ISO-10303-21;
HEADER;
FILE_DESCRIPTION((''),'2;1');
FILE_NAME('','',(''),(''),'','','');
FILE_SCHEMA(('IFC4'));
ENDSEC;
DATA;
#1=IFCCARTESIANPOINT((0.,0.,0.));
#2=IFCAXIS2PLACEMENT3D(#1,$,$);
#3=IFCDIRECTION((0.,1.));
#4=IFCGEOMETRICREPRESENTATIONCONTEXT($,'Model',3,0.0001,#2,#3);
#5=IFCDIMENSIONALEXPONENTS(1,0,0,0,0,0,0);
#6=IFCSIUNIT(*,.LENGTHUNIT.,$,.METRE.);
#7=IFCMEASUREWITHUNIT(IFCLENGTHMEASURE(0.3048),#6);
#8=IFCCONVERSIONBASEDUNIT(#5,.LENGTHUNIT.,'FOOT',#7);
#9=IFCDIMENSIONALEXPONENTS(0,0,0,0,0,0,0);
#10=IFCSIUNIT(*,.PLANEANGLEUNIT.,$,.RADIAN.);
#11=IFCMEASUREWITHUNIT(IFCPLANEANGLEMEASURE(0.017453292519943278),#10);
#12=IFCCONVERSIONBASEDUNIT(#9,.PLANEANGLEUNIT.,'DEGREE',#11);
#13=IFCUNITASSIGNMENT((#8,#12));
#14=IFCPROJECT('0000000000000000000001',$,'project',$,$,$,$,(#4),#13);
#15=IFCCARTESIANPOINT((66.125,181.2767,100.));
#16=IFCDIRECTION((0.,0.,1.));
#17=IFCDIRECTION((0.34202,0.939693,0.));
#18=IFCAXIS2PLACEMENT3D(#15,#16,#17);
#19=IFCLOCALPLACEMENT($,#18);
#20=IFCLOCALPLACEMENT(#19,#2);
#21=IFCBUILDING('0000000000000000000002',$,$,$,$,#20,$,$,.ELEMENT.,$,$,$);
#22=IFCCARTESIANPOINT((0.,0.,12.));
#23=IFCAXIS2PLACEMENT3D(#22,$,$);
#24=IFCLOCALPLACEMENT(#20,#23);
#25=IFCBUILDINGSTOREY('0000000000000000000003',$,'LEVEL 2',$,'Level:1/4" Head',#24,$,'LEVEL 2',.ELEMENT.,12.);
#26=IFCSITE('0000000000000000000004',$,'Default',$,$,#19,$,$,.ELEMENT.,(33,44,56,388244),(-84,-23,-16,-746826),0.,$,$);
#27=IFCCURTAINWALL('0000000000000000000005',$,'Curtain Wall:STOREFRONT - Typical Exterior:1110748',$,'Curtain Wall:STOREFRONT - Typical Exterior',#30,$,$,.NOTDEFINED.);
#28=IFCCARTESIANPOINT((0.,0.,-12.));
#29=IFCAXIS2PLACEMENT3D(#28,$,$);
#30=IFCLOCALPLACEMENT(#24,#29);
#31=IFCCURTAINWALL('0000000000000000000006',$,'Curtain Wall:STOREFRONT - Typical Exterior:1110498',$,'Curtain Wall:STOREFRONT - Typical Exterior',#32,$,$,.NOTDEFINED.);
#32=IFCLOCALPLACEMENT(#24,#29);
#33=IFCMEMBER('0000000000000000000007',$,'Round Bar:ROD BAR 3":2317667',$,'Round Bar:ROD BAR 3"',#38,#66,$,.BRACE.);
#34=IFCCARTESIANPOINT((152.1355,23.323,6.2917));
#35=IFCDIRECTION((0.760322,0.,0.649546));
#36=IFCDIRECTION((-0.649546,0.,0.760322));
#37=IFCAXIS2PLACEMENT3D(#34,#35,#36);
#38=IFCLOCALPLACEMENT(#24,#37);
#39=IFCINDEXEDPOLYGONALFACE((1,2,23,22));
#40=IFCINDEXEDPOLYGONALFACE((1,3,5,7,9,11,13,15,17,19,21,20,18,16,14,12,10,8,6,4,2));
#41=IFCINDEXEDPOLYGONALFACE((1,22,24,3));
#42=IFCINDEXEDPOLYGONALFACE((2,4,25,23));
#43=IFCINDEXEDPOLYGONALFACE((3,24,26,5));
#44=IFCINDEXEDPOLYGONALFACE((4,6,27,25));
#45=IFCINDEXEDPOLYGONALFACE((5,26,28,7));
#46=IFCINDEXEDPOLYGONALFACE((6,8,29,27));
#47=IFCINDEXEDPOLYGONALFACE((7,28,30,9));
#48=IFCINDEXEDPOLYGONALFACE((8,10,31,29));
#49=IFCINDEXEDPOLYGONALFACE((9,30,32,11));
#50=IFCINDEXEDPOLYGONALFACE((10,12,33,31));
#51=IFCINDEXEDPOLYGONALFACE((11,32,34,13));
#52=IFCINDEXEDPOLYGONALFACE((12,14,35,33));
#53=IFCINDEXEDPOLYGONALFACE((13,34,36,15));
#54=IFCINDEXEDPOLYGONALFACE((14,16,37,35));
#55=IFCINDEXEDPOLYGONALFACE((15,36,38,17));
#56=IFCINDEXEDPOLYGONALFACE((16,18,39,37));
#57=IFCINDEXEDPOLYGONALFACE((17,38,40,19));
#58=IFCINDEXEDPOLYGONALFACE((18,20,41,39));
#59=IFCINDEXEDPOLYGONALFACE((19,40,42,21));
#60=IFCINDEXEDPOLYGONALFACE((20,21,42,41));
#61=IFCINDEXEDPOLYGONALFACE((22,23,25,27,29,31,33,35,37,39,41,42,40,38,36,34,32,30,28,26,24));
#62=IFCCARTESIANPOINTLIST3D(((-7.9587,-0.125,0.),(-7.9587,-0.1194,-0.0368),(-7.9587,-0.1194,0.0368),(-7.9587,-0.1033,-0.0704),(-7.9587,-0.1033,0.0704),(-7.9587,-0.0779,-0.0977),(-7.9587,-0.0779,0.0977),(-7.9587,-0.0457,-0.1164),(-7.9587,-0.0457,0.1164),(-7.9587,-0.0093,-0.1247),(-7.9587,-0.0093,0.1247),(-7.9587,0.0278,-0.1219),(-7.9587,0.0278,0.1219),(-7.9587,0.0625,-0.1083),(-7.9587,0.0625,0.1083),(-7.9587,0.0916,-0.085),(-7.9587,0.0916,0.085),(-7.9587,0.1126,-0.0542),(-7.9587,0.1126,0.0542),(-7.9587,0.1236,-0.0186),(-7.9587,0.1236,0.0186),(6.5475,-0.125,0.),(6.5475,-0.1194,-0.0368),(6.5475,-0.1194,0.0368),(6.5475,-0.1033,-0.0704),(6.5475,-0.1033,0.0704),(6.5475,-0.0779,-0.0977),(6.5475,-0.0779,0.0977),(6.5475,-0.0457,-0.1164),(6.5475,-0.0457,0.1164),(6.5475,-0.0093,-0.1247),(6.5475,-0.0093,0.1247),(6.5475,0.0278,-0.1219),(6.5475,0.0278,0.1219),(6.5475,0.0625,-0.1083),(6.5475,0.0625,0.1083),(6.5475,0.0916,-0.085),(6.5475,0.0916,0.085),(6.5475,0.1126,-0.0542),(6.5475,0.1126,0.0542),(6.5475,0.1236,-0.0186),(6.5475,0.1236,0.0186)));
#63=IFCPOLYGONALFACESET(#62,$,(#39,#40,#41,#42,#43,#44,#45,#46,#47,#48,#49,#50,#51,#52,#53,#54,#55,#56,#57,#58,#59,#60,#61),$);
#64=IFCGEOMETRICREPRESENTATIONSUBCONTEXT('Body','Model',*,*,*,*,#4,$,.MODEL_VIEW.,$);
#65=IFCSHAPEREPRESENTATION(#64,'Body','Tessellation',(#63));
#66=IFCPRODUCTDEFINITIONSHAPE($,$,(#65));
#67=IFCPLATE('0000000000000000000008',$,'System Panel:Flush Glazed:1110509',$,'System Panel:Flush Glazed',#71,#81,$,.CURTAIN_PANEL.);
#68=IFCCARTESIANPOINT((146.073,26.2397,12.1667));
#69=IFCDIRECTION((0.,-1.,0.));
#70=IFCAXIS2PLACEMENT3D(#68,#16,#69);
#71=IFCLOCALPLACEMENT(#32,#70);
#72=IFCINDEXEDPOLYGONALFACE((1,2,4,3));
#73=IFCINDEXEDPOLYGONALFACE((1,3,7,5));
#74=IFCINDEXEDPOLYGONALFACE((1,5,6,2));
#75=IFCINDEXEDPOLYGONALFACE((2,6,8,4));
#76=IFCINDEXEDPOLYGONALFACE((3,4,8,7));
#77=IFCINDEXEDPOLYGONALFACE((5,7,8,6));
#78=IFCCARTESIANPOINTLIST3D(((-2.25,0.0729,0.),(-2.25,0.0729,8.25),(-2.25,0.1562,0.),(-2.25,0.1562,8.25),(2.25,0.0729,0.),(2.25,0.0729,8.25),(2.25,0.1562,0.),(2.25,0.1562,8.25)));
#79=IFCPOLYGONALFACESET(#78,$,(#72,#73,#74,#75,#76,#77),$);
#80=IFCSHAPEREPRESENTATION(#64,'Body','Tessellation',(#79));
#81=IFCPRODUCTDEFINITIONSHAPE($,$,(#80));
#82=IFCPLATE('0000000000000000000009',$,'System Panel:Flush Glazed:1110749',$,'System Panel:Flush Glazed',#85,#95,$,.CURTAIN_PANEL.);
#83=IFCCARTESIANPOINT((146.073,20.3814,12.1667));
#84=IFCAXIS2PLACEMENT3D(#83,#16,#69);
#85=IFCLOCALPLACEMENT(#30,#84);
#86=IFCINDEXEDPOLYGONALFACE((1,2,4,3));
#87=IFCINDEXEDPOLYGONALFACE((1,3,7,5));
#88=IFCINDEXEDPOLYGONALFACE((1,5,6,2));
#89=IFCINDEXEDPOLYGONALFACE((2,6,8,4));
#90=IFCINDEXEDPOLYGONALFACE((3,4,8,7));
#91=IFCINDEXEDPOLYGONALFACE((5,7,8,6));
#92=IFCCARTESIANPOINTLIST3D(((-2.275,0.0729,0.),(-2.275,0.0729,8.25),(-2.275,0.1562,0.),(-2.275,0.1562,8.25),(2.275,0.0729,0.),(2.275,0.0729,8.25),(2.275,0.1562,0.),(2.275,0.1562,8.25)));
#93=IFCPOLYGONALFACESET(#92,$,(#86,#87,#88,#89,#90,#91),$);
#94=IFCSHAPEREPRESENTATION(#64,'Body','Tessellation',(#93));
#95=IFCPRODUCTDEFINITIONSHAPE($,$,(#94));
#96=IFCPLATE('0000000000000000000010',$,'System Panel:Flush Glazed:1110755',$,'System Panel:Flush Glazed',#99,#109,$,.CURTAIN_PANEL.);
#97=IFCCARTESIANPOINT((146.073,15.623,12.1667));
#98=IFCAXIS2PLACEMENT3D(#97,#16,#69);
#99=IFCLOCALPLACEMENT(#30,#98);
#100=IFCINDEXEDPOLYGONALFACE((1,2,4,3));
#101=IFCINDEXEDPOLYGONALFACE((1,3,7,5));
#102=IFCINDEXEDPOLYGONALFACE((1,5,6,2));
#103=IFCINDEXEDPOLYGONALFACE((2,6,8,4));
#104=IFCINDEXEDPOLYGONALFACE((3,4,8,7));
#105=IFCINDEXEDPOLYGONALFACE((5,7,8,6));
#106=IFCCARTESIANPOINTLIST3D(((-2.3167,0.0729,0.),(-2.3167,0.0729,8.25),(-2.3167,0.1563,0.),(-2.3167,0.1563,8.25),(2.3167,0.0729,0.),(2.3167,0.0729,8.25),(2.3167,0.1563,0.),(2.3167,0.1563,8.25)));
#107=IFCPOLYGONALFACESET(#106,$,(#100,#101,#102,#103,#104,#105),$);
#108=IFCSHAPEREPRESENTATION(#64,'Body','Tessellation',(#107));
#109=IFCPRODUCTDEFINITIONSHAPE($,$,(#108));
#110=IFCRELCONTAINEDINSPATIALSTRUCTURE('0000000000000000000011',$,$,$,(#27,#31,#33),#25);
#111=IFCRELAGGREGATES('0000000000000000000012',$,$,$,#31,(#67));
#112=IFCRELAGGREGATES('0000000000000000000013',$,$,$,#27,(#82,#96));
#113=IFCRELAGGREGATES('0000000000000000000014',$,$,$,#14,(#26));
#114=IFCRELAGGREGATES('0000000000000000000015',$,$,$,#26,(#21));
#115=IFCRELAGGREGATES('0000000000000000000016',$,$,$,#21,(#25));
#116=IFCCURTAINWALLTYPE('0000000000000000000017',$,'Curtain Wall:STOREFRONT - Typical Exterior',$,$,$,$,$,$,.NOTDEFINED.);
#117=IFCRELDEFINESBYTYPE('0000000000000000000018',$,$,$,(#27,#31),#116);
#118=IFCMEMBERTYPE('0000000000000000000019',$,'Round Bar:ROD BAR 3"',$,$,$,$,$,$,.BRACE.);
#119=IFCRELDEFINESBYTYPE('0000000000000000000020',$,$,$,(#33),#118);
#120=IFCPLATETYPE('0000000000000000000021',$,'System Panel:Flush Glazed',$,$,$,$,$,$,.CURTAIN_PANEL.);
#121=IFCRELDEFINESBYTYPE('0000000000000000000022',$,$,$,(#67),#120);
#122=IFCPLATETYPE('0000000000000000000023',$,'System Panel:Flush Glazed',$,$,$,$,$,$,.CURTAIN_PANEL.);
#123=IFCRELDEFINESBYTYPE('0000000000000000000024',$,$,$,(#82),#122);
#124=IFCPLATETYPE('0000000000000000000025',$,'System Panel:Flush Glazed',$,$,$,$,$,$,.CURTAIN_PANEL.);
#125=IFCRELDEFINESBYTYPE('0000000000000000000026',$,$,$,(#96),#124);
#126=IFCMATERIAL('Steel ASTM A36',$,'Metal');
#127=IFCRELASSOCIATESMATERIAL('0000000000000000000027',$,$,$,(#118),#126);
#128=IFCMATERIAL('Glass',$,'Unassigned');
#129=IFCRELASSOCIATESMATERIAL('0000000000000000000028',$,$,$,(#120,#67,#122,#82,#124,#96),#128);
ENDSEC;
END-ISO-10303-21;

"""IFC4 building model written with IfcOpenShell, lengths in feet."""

from ifc_helpers import new_model, entity, si_unit, converted_unit, direction, frame, frame_2d, origin, place, context, subcontext, project, spatial, rectangle, circle, extrude, source, transform, mapped, material, material_profile, profile_set, type_object, type_shapes, element, aggregate, save


model = new_model("IFC4")

# Units and contexts
model_context = context("Model", 3, precision=0.0001, world=origin(), true_north=direction((0.0, 1.0)))
body_context = subcontext(model_context, "Body", "Model", "MODEL_VIEW")
ifc_project = project(units=[converted_unit("LENGTHUNIT", "FOOT", entity("IfcLengthMeasure", 0.3048), si_unit("LENGTHUNIT", "METRE"), dimensions=[1, 0, 0, 0, 0, 0, 0]), converted_unit("PLANEANGLEUNIT", "DEGREE", entity("IfcPlaneAngleMeasure", 0.017453292519943278), si_unit("PLANEANGLEUNIT", "RADIAN"), dimensions=[0, 0, 0, 0, 0, 0, 0])], contexts=[model_context])

# Site, building, storey
site_placement = place(None, frame((66.125, 181.2767, 100.0), z_axis=(0.0, 0.0, 1.0), x_axis=(0.34202, 0.939693, 0.0)))
site = spatial("IfcSite", under=ifc_project, at=site_placement, Name="Default", CompositionType="ELEMENT", RefLatitude=(33, 44, 56, 388244), RefLongitude=(-84, -23, -16, -746826), RefElevation=0.0)
building_placement = place(site_placement, origin())
building = spatial("IfcBuilding", under=site, at=building_placement, CompositionType="ELEMENT")
storey_placement = place(building_placement, frame((0.0, 0.0, 12.0)))
storey = spatial("IfcBuildingStorey", under=building, at=storey_placement, Name="LEVEL 2", ObjectType="Level:1/4\" Head", LongName="LEVEL 2", CompositionType="ELEMENT", Elevation=12.0)

# Curtain walls
curtain_wall_type = type_object("IfcCurtainWallType", Name="Curtain Wall:STOREFRONT - Typical Exterior", PredefinedType="NOTDEFINED")
curtain_wall_1_placement = place(storey_placement, frame((0.0, 0.0, -12.0)))
curtain_wall_1 = element("IfcCurtainWall", 1, at=curtain_wall_1_placement, inside=storey, type_object=curtain_wall_type, Name="Curtain Wall:STOREFRONT - Typical Exterior:1110748", ObjectType="Curtain Wall:STOREFRONT - Typical Exterior", PredefinedType="NOTDEFINED")
curtain_wall_2_placement = place(storey_placement, frame((0.0, 0.0, -12.0)))
curtain_wall_2 = element("IfcCurtainWall", 2, at=curtain_wall_2_placement, inside=storey, type_object=curtain_wall_type, Name="Curtain Wall:STOREFRONT - Typical Exterior:1110498", ObjectType="Curtain Wall:STOREFRONT - Typical Exterior", PredefinedType="NOTDEFINED")

# Member
ifc_material_1 = material(Name="Steel ASTM A36", Category="Metal")
ifc_material_profile_1 = material_profile(ifc_material_1, circle(Radius=0.125, at=frame_2d((0.0, 0.0), x_axis=(1.0, 0.0))), Name="ROD BAR 3\"")
ifc_profile_set_1 = profile_set([ifc_material_profile_1], Name="ROD BAR 3\"")
member_type_1 = type_object("IfcMemberType", Name="Round Bar:ROD BAR 3\"", PredefinedType="BRACE", material=ifc_profile_set_1)
shared_shape_1 = source(origin(), body_context, "Body", "SweptSolid", [
    extrude(circle(Radius=0.125, at=frame_2d((0.0, 0.0), x_axis=(1.0, 0.0))), frame((-7.9587, 0.0, 0.0), z_axis=(1.0, 0.0, 0.0), x_axis=(0.0, -1.0, 0.0)), (0.0, 0.0, 1.0), 14.5062),
])
type_shapes(member_type_1, [shared_shape_1])
member_1_placement = place(storey_placement, frame((152.1355, 23.323, 6.2917), z_axis=(0.760322, 0.0, 0.649546), x_axis=(-0.649546, 0.0, 0.760322)))
element("IfcMember", 3, at=member_1_placement, inside=storey, type_object=member_type_1, Name="Round Bar:ROD BAR 3\":2317667", ObjectType="Round Bar:ROD BAR 3\"", PredefinedType="BRACE", context=body_context, shape_type="MappedRepresentation", body=[
    mapped(shared_shape_1, transform((0.0, 0.0, 0.0), scale=1.0)),
])

# Plates
ifc_material_2 = material(Name="Glass", Category="Unassigned")
plate_type_1 = type_object("IfcPlateType", Name="System Panel:Flush Glazed", PredefinedType="CURTAIN_PANEL", material=ifc_material_2)
shared_shape_2 = source(origin(), body_context, "Body", "SweptSolid", [
    extrude(rectangle(XDim=0.0833, YDim=4.5, at=frame_2d((0.0, 0.0), x_axis=(1.0, 0.0))), frame((0.0, 0.1146, 0.0), z_axis=(0.0, 0.0, 1.0), x_axis=(0.0, 1.0, 0.0)), (0.0, 0.0, 1.0), 8.25),
])
type_shapes(plate_type_1, [shared_shape_2])
plate_1_placement = place(curtain_wall_2_placement, frame((146.073, 26.2397, 12.1667), z_axis=(0.0, 0.0, 1.0), x_axis=(0.0, -1.0, 0.0)))
plate_1 = element("IfcPlate", 4, at=plate_1_placement, type_object=plate_type_1, material=ifc_material_2, Name="System Panel:Flush Glazed:1110509", ObjectType="System Panel:Flush Glazed", PredefinedType="CURTAIN_PANEL", context=body_context, shape_type="MappedRepresentation", body=[
    mapped(shared_shape_2, transform((0.0, 0.0, 0.0), scale=1.0)),
])
aggregate(curtain_wall_2, [plate_1])
plate_type_2 = type_object("IfcPlateType", Name="System Panel:Flush Glazed", PredefinedType="CURTAIN_PANEL", material=ifc_material_2)
shared_shape_3 = source(origin(), body_context, "Body", "SweptSolid", [
    extrude(rectangle(XDim=0.0833, YDim=4.55, at=frame_2d((0.0, 0.0), x_axis=(1.0, 0.0))), frame((0.0, 0.1146, 0.0), z_axis=(0.0, 0.0, 1.0), x_axis=(0.0, 1.0, 0.0)), (0.0, 0.0, 1.0), 8.25),
])
type_shapes(plate_type_2, [shared_shape_3])
plate_2_placement = place(curtain_wall_1_placement, frame((146.073, 20.3814, 12.1667), z_axis=(0.0, 0.0, 1.0), x_axis=(0.0, -1.0, 0.0)))
plate_2 = element("IfcPlate", 5, at=plate_2_placement, type_object=plate_type_2, material=ifc_material_2, Name="System Panel:Flush Glazed:1110749", ObjectType="System Panel:Flush Glazed", PredefinedType="CURTAIN_PANEL", context=body_context, shape_type="MappedRepresentation", body=[
    mapped(shared_shape_3, transform((0.0, 0.0, 0.0), scale=1.0)),
])
plate_type_3 = type_object("IfcPlateType", Name="System Panel:Flush Glazed", PredefinedType="CURTAIN_PANEL", material=ifc_material_2)
shared_shape_4 = source(origin(), body_context, "Body", "SweptSolid", [
    extrude(rectangle(XDim=0.0833, YDim=4.6333, at=frame_2d((0.0, 0.0), x_axis=(1.0, 0.0))), frame((0.0, 0.1146, 0.0), z_axis=(0.0, 0.0, 1.0), x_axis=(0.0, 1.0, 0.0)), (0.0, 0.0, 1.0), 8.25),
])
type_shapes(plate_type_3, [shared_shape_4])
plate_3_placement = place(curtain_wall_1_placement, frame((146.073, 15.623, 12.1667), z_axis=(0.0, 0.0, 1.0), x_axis=(0.0, -1.0, 0.0)))
plate_3 = element("IfcPlate", 6, at=plate_3_placement, type_object=plate_type_3, material=ifc_material_2, Name="System Panel:Flush Glazed:1110755", ObjectType="System Panel:Flush Glazed", PredefinedType="CURTAIN_PANEL", context=body_context, shape_type="MappedRepresentation", body=[
    mapped(shared_shape_4, transform((0.0, 0.0, 0.0), scale=1.0)),
])
aggregate(curtain_wall_1, [plate_2, plate_3])

save(model, "model.ifc")
